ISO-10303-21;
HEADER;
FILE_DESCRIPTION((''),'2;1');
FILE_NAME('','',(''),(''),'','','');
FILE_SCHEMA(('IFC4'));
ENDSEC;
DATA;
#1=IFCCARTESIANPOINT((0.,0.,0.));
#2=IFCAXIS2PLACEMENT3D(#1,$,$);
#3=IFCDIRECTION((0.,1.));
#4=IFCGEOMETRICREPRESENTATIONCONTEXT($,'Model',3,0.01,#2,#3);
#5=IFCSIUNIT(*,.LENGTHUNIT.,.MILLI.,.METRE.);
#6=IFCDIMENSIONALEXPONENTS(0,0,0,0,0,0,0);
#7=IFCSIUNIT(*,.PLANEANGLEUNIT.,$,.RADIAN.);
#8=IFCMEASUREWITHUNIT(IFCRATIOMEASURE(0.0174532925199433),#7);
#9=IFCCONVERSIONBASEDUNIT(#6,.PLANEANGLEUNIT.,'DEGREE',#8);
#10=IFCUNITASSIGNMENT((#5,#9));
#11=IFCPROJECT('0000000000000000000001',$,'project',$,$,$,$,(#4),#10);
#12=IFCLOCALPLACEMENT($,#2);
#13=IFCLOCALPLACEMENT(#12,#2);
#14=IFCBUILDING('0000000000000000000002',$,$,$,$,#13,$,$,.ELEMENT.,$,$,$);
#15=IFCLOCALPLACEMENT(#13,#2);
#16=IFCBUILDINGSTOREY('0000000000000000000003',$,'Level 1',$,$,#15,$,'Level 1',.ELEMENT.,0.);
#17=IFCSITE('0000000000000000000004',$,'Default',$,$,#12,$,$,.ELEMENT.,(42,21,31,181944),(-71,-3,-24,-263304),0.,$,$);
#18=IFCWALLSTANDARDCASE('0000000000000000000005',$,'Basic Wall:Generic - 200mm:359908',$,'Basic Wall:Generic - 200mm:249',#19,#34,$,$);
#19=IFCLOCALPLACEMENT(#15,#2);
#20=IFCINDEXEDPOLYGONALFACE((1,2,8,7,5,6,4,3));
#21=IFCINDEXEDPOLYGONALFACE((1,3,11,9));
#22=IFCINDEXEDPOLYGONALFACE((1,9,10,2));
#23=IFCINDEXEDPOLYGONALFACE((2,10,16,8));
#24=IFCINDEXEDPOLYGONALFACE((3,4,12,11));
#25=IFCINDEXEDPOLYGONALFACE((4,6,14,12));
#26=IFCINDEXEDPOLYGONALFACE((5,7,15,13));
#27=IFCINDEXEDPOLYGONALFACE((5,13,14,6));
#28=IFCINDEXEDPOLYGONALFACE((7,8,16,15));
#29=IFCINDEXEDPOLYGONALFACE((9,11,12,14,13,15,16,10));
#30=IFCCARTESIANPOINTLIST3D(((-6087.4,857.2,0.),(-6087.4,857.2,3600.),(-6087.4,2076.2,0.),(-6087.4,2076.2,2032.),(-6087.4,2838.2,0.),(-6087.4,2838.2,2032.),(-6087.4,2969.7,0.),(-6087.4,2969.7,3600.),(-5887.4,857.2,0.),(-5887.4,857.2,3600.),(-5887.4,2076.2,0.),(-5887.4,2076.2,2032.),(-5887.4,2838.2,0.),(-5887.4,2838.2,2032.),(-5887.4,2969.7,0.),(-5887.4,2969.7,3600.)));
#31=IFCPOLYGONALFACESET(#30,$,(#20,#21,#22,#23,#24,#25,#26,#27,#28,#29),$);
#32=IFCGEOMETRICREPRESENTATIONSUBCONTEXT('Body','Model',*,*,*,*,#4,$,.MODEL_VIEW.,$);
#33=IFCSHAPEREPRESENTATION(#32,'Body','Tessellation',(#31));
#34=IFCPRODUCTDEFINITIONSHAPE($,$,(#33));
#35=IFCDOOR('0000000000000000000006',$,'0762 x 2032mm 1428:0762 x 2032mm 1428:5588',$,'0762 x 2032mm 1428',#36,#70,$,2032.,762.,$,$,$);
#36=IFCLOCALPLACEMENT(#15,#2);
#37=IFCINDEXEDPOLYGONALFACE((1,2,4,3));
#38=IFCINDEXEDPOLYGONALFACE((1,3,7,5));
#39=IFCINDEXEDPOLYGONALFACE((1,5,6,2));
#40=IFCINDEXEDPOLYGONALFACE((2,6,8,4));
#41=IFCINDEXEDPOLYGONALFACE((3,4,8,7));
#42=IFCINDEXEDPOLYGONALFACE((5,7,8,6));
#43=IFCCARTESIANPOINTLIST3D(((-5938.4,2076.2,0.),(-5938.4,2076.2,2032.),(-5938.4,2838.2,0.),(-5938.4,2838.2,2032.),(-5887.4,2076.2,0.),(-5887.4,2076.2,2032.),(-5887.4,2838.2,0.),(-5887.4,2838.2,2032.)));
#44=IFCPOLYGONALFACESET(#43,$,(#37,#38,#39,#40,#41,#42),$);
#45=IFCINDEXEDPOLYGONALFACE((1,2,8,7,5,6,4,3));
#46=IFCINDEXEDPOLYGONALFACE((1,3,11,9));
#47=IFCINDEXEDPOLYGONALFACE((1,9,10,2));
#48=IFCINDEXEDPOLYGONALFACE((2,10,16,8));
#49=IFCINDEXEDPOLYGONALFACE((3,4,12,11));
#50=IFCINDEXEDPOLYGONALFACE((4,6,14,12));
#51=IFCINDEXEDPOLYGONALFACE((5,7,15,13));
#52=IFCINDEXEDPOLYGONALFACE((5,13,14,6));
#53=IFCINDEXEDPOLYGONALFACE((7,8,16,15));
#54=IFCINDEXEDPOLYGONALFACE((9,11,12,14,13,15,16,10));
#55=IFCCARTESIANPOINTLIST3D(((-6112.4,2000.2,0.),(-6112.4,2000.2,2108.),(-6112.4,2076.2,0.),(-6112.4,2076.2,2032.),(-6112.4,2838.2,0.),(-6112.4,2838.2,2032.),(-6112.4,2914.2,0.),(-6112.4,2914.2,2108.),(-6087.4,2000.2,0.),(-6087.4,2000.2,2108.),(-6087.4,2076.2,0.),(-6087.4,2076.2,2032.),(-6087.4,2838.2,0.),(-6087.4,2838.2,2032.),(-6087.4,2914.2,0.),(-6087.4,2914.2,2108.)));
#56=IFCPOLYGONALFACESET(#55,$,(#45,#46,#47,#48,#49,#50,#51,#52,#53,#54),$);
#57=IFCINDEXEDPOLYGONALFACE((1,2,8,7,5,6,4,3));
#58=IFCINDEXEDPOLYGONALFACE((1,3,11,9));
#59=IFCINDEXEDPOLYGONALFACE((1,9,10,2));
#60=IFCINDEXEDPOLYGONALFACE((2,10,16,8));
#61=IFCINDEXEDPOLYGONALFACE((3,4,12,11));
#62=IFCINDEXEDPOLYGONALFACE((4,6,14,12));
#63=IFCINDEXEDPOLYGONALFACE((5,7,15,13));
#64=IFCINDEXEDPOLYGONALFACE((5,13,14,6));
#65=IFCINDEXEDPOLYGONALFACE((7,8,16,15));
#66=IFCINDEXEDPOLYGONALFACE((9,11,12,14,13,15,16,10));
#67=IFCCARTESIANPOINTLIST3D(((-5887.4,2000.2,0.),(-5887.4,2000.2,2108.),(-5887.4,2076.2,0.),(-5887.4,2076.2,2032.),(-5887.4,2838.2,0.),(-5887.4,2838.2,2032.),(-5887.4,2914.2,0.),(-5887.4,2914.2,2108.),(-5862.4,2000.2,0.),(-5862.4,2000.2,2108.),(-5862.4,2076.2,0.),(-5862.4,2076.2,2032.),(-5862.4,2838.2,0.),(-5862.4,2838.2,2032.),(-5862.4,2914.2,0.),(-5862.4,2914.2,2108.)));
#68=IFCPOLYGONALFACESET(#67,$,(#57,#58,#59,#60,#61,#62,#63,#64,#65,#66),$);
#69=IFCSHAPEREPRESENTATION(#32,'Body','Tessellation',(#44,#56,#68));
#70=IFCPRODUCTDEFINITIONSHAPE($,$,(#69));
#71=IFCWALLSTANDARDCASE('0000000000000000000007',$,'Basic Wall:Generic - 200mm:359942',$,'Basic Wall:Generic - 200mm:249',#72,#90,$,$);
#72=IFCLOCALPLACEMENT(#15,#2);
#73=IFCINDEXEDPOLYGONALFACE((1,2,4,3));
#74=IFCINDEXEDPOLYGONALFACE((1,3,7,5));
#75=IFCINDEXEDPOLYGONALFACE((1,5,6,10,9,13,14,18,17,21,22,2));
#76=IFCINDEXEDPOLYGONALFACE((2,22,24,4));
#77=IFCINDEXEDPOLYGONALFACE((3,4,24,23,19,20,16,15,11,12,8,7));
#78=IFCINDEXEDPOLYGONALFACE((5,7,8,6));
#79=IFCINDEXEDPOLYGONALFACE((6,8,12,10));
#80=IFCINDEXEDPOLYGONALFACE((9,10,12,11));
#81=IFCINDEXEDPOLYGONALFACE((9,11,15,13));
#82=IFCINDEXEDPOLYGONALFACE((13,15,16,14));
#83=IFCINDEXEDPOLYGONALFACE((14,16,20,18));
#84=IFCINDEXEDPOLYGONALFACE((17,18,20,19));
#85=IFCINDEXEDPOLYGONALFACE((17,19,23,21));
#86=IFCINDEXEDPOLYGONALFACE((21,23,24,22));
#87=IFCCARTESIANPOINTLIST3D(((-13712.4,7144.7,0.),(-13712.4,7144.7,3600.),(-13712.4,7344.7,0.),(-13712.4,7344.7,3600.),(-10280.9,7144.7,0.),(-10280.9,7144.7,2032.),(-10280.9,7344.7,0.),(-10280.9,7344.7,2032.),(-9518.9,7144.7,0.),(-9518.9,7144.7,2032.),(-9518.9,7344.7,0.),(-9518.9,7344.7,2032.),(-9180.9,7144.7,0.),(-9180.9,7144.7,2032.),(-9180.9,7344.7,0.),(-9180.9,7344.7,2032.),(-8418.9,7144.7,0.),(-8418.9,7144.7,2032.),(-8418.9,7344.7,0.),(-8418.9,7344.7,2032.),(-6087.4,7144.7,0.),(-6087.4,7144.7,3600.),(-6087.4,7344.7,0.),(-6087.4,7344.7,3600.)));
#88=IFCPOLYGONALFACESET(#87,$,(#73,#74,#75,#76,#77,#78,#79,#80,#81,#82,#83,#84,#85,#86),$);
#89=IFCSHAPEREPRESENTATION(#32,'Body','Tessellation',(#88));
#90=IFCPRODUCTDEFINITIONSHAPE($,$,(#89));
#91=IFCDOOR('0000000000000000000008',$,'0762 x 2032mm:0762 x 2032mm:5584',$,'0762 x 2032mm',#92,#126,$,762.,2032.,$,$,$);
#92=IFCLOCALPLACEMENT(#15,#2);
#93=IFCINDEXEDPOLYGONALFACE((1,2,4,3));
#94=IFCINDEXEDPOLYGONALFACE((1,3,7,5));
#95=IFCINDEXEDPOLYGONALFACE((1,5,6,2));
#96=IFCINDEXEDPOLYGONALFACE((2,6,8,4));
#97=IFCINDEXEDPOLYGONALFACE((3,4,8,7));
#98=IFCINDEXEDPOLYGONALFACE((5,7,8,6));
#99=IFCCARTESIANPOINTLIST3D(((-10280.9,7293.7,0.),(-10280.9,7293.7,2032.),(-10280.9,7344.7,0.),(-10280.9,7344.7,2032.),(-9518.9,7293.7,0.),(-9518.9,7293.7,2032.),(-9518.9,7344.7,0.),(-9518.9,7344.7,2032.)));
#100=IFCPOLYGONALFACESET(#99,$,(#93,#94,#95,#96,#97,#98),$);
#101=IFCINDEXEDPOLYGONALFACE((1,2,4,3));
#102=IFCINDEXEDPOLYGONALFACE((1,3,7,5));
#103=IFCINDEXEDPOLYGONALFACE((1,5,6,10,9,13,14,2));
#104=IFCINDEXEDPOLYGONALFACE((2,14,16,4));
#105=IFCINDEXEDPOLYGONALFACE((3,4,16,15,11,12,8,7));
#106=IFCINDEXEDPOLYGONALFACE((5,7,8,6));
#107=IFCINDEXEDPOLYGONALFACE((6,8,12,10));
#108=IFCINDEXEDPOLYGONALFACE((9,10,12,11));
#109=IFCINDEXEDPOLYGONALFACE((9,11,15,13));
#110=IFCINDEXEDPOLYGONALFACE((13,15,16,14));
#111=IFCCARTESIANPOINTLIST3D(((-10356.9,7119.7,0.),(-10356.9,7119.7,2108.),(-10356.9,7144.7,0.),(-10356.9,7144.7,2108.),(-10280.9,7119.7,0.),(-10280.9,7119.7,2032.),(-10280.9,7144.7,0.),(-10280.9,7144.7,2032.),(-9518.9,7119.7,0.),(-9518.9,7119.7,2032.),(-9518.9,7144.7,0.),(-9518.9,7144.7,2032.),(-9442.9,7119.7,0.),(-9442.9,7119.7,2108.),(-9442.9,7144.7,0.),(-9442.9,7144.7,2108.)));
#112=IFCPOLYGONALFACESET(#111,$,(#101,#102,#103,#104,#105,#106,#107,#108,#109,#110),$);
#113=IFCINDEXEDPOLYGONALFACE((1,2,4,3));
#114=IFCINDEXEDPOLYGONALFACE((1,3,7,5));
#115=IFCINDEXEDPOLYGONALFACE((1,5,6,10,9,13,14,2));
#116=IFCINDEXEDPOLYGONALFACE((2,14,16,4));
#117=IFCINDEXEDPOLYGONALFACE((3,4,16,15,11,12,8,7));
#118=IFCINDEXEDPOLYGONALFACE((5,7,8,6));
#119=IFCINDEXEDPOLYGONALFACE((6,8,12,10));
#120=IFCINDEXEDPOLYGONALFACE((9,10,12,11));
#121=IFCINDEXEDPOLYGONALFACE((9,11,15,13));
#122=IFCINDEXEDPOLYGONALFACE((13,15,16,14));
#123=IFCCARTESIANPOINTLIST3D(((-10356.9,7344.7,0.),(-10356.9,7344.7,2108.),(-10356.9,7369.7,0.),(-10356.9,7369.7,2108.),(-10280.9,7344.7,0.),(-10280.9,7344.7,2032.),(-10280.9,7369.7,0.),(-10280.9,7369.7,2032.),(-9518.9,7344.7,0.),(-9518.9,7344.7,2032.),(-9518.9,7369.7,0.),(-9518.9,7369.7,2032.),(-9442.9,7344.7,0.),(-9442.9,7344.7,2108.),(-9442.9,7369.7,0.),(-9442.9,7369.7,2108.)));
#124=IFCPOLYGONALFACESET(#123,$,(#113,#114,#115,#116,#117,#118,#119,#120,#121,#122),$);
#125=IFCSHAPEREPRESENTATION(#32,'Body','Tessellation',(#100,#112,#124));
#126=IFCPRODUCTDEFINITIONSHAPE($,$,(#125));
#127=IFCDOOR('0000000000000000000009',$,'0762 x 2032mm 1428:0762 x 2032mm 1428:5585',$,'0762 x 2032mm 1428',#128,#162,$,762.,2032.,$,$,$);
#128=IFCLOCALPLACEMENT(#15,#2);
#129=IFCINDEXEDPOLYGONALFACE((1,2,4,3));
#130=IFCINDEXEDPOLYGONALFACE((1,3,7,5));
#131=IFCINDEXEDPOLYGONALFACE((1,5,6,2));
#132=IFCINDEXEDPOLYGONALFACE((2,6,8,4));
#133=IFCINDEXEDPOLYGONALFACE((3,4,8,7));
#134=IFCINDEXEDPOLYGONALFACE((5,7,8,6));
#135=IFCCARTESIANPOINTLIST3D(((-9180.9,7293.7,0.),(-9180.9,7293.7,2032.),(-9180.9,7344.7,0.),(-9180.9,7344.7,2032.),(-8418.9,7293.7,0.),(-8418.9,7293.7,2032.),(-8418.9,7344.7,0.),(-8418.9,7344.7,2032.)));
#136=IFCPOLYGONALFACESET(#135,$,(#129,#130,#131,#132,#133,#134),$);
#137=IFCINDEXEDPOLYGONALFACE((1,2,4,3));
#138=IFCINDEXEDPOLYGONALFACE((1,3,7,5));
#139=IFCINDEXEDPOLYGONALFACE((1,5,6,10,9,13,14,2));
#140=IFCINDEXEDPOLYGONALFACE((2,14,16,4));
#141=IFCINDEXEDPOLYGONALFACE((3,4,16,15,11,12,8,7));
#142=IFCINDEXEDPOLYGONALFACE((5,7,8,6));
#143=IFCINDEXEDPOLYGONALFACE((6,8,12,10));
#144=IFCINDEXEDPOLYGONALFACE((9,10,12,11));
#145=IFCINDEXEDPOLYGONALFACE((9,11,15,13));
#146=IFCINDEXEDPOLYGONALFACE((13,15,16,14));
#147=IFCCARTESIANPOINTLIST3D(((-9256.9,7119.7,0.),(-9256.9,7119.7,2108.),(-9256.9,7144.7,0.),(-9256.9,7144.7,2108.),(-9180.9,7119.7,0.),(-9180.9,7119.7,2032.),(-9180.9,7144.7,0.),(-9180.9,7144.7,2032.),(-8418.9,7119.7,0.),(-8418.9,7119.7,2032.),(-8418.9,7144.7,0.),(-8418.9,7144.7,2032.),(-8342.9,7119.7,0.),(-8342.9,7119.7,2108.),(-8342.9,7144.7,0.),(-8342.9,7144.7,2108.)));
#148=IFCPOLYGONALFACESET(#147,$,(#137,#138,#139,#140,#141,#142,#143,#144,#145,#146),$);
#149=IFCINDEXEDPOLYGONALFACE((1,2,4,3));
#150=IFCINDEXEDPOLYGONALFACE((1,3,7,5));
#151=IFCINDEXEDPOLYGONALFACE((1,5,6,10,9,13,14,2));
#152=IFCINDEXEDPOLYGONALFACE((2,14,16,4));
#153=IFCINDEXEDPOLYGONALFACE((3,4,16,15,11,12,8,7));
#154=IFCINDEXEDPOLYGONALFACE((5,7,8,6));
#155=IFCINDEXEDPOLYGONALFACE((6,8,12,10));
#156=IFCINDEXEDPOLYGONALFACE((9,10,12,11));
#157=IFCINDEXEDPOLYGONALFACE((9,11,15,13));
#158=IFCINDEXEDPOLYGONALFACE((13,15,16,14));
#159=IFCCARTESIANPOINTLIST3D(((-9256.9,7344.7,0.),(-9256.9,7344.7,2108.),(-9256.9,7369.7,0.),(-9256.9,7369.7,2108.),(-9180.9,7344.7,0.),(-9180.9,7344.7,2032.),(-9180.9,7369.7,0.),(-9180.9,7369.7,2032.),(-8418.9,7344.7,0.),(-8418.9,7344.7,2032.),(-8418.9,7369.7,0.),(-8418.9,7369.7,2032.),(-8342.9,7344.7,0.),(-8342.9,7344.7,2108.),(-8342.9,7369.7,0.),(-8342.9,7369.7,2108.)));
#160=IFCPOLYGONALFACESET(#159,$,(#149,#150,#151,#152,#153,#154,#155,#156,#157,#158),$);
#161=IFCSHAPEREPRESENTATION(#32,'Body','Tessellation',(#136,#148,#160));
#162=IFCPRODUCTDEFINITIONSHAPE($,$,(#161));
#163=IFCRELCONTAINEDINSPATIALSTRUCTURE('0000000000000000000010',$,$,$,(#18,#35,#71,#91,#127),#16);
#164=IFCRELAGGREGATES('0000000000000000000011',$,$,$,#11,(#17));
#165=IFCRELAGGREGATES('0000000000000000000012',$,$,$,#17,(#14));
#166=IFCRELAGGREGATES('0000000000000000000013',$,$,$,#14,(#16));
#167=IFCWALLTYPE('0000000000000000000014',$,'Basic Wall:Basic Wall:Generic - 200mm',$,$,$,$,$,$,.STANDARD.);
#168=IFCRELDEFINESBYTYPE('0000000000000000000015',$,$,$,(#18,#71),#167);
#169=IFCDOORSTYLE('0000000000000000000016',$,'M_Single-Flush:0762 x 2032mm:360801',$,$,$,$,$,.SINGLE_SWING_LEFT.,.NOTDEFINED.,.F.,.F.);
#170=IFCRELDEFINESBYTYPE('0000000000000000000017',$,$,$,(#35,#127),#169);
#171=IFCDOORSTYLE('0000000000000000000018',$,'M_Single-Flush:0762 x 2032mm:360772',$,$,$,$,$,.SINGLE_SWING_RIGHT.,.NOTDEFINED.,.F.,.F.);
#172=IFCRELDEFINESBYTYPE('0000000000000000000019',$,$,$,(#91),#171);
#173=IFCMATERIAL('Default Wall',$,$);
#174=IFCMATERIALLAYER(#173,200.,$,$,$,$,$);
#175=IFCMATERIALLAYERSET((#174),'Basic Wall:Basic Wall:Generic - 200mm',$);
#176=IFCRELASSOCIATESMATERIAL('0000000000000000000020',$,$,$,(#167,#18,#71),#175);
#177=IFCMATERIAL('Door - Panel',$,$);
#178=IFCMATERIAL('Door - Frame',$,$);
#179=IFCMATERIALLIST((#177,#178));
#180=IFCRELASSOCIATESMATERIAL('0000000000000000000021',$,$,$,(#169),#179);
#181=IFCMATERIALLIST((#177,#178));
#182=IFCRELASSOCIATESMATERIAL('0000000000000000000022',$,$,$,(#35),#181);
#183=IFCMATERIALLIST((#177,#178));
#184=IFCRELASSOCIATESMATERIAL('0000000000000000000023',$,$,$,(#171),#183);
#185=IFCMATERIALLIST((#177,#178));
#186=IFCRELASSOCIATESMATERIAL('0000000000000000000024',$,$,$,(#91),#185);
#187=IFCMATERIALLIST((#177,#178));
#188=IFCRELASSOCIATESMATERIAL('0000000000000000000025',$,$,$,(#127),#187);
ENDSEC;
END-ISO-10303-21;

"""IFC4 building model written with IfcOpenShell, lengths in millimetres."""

from ifc_helpers import new_model, entity, si_unit, converted_unit, direction, frame, frame_2d, origin, origin_2d_with_axis, place, context, subcontext, project, spatial, polyline, rectangle, outline, extrude, source, transform, mapped, material, material_list, layer, layer_set, layer_usage, type_object, type_shapes, element, fill, save


model = new_model("IFC4")

# Units and contexts
model_context = context("Model", 3, precision=0.01, world=origin(), true_north=direction((0.0, 1.0)))
body_context = subcontext(model_context, "Body", "Model", "MODEL_VIEW")
ifc_project = project(units=[si_unit("LENGTHUNIT", "METRE", prefix="MILLI"), converted_unit("PLANEANGLEUNIT", "DEGREE", entity("IfcRatioMeasure", 0.0174532925199433), si_unit("PLANEANGLEUNIT", "RADIAN"), dimensions=[0, 0, 0, 0, 0, 0, 0])], contexts=[model_context])

# Site, building, storey
site_placement = place(None, origin())
site = spatial("IfcSite", under=ifc_project, at=site_placement, Name="Default", CompositionType="ELEMENT", RefLatitude=(42, 21, 31, 181944), RefLongitude=(-71, -3, -24, -263304), RefElevation=0.0)
building_placement = place(site_placement, origin())
building = spatial("IfcBuilding", under=site, at=building_placement, CompositionType="ELEMENT")
storey_placement = place(building_placement, origin())
storey = spatial("IfcBuildingStorey", under=building, at=storey_placement, Name="Level 1", LongName="Level 1", CompositionType="ELEMENT", Elevation=0.0)

# Shared definitions
ifc_material_1 = material(Name="Default Wall")
ifc_material_2 = material(Name="Door - Panel")
ifc_material_3 = material(Name="Door - Frame")

# Wall, opening, door
ifc_layer_1 = layer(ifc_material_1, 200.0)
ifc_layer_set_1 = layer_set([ifc_layer_1], Name="Basic Wall:Basic Wall:Generic - 200mm")
ifc_layer_usage_1 = layer_usage(ifc_layer_set_1, "AXIS2", "NEGATIVE", 100.0)
wall_type_1 = type_object("IfcWallType", Name="Basic Wall:Basic Wall:Generic - 200mm", PredefinedType="STANDARD", material=ifc_layer_set_1)
wall_1_placement = place(storey_placement, frame((-5987.4, 857.2, 0.0), z_axis=(0.0, 0.0, 1.0), x_axis=(0.0, 1.0, 0.0)))
wall_1 = element("IfcWallStandardCase", 1, at=wall_1_placement, inside=storey, type_object=wall_type_1, material=ifc_layer_usage_1, Name="Basic Wall:Generic - 200mm:359908", ObjectType="Basic Wall:Generic - 200mm:249", context=body_context, shape_type="SweptSolid", body=[
    extrude(rectangle(XDim=2112.5, YDim=200.0, at=frame_2d((1056.2, 0.0), x_axis=(-1.0, 0.0))), origin(), (0.0, 0.0, 1.0), 3600.0),
])
opening_1_placement = place(wall_1_placement, frame((-857.2, -5987.4, 0.0), z_axis=(0.0, 0.0, 1.0), x_axis=(0.0, -1.0, 0.0)))
opening_1 = element("IfcOpeningElement", 2, at=opening_1_placement, cuts=wall_1, ObjectType="Opening", context=body_context, shape_type="SweptSolid", body=[
    extrude(rectangle(XDim=2032.0, YDim=762.0, at=frame_2d((0.0, 0.0), x_axis=(0.0, 1.0))), frame((-5885.4, 2457.2, 1016.0), z_axis=(-1.0, 0.0, 0.0), x_axis=(0.0, -1.0, 0.0)), (0.0, 0.0, 1.0), 204.0),
])
ifc_material_list_1 = material_list([ifc_material_2, ifc_material_3])
ifc_material_list_2 = material_list([ifc_material_2, ifc_material_3])
door_style_1 = type_object("IfcDoorStyle", Name="M_Single-Flush:0762 x 2032mm:360801", ConstructionType="NOTDEFINED", OperationType="SINGLE_SWING_LEFT", ParameterTakesPrecedence=False, Sizeable=False, material=ifc_material_list_2)
shared_shape_1 = source(origin(), body_context, "Body", "SweptSolid", [
    extrude(rectangle(XDim=51.0, YDim=762.0, at=origin_2d_with_axis()), frame((381.0, -27.5, 0.0), z_axis=(0.0, 0.0, 1.0), x_axis=(0.0, 1.0, 0.0)), (0.0, 0.0, 1.0), 2032.0),
    extrude(outline(polyline([(-1035.0, -457.0), (1073.0, -457.0), (1073.0, 457.0), (-1035.0, 457.0), (-1035.0, 381.0), (997.0, 381.0), (997.0, -381.0), (-1035.0, -381.0), (-1035.0, -457.0)])), frame((381.0, -227.0, 1035.0), z_axis=(0.0, 1.0, 0.0), x_axis=(0.0, 0.0, 1.0)), (0.0, 0.0, 1.0), 25.0),
    extrude(outline(polyline([(-457.0, -1073.0), (457.0, -1073.0), (457.0, 1035.0), (381.0, 1035.0), (381.0, -997.0), (-381.0, -997.0), (-381.0, 1035.0), (-457.0, 1035.0), (-457.0, -1073.0)])), frame((381.0, -2.0, 1035.0), z_axis=(0.0, 1.0, 0.0), x_axis=(1.0, 0.0, 0.0)), (0.0, 0.0, 1.0), 25.0),
])
type_shapes(door_style_1, [shared_shape_1])
door_1_placement = place(opening_1_placement, frame((-5885.4, 2838.2, 0.0), z_axis=(0.0, 0.0, 1.0), x_axis=(0.0, -1.0, 0.0)))
door_1 = element("IfcDoor", 3, at=door_1_placement, inside=storey, type_object=door_style_1, material=ifc_material_list_1, Name="0762 x 2032mm 1428:0762 x 2032mm 1428:5588", ObjectType="0762 x 2032mm 1428", OverallHeight=2032.0, OverallWidth=762.0, context=body_context, shape_type="MappedRepresentation", body=[
    mapped(shared_shape_1, transform((0.0, 0.0, 0.0), scale=1.0)),
])
fill(opening_1, door_1)

# Wall, openings, doors
ifc_layer_usage_2 = layer_usage(ifc_layer_set_1, "AXIS2", "NEGATIVE", 100.0)
wall_2_placement = place(storey_placement, frame((-13712.4, 7244.7, 0.0)))
wall_2 = element("IfcWallStandardCase", 4, at=wall_2_placement, inside=storey, type_object=wall_type_1, material=ifc_layer_usage_2, Name="Basic Wall:Generic - 200mm:359942", ObjectType="Basic Wall:Generic - 200mm:249", context=body_context, shape_type="SweptSolid", body=[
    extrude(rectangle(XDim=7625.0, YDim=200.0, at=frame_2d((3812.5, 0.0), x_axis=(-1.0, 0.0))), origin(), (0.0, 0.0, 1.0), 3600.0),
])
opening_2_placement = place(wall_2_placement, frame((13712.4, -7244.7, 0.0)))
opening_2 = element("IfcOpeningElement", 5, at=opening_2_placement, cuts=wall_2, ObjectType="Opening", context=body_context, shape_type="SweptSolid", body=[
    extrude(rectangle(XDim=2032.0, YDim=762.0, at=origin_2d_with_axis()), frame((-9899.9, 7142.7, 1016.0), z_axis=(0.0, 1.0, 0.0), x_axis=(0.0, 0.0, -1.0)), (0.0, 0.0, 1.0), 204.0),
])
opening_3_placement = place(wall_2_placement, frame((13712.4, -7244.7, 0.0)))
opening_3 = element("IfcOpeningElement", 6, at=opening_3_placement, cuts=wall_2, ObjectType="Opening", context=body_context, shape_type="SweptSolid", body=[
    extrude(rectangle(XDim=2032.0, YDim=762.0, at=origin_2d_with_axis()), frame((-8799.9, 7142.7, 1016.0), z_axis=(0.0, 1.0, 0.0), x_axis=(0.0, 0.0, 1.0)), (0.0, 0.0, 1.0), 204.0),
])
ifc_material_list_3 = material_list([ifc_material_2, ifc_material_3])
ifc_material_list_4 = material_list([ifc_material_2, ifc_material_3])
door_style_2 = type_object("IfcDoorStyle", Name="M_Single-Flush:0762 x 2032mm:360772", ConstructionType="NOTDEFINED", OperationType="SINGLE_SWING_RIGHT", ParameterTakesPrecedence=False, Sizeable=False, material=ifc_material_list_4)
shared_shape_2 = source(origin(), body_context, "Body", "SweptSolid", [
    extrude(rectangle(XDim=762.0, YDim=51.0, at=frame_2d((0.0, 0.0), x_axis=(1.0, 0.0))), frame((381.0, -27.5, 0.0), z_axis=(0.0, 0.0, 1.0), x_axis=(-1.0, 0.0, 0.0)), (0.0, 0.0, 1.0), 2032.0),
    extrude(outline(polyline([(-457.0, -1035.0), (-381.0, -1035.0), (-381.0, 997.0), (381.0, 997.0), (381.0, -1035.0), (457.0, -1035.0), (457.0, 1073.0), (-457.0, 1073.0), (-457.0, -1035.0)])), frame((381.0, -227.0, 1035.0), z_axis=(0.0, 1.0, 0.0), x_axis=(-1.0, 0.0, 0.0)), (0.0, 0.0, 1.0), 25.0),
    extrude(outline(polyline([(-1073.0, -457.0), (1035.0, -457.0), (1035.0, -381.0), (-997.0, -381.0), (-997.0, 381.0), (1035.0, 381.0), (1035.0, 457.0), (-1073.0, 457.0), (-1073.0, -457.0)])), frame((381.0, -2.0, 1035.0), z_axis=(0.0, 1.0, 0.0), x_axis=(0.0, 0.0, -1.0)), (0.0, 0.0, 1.0), 25.0),
])
type_shapes(door_style_2, [shared_shape_2])
door_2_placement = place(opening_2_placement, frame((-10280.9, 7346.7, 0.0)))
door_2 = element("IfcDoor", 7, at=door_2_placement, inside=storey, type_object=door_style_2, material=ifc_material_list_3, Name="0762 x 2032mm:0762 x 2032mm:5584", ObjectType="0762 x 2032mm", OverallHeight=762.0, OverallWidth=2032.0, context=body_context, shape_type="MappedRepresentation", body=[
    mapped(shared_shape_2, transform((0.0, 0.0, 0.0), scale=1.0)),
])
fill(opening_2, door_2)
ifc_material_list_5 = material_list([ifc_material_2, ifc_material_3])
door_3_placement = place(opening_3_placement, frame((-9180.9, 7346.7, 0.0)))
door_3 = element("IfcDoor", 8, at=door_3_placement, inside=storey, type_object=door_style_1, material=ifc_material_list_5, Name="0762 x 2032mm 1428:0762 x 2032mm 1428:5585", ObjectType="0762 x 2032mm 1428", OverallHeight=762.0, OverallWidth=2032.0, context=body_context, shape_type="MappedRepresentation", body=[
    mapped(shared_shape_1, transform((0.0, 0.0, 0.0), scale=1.0)),
])
fill(opening_3, door_3)

save(model, "model.ifc")
